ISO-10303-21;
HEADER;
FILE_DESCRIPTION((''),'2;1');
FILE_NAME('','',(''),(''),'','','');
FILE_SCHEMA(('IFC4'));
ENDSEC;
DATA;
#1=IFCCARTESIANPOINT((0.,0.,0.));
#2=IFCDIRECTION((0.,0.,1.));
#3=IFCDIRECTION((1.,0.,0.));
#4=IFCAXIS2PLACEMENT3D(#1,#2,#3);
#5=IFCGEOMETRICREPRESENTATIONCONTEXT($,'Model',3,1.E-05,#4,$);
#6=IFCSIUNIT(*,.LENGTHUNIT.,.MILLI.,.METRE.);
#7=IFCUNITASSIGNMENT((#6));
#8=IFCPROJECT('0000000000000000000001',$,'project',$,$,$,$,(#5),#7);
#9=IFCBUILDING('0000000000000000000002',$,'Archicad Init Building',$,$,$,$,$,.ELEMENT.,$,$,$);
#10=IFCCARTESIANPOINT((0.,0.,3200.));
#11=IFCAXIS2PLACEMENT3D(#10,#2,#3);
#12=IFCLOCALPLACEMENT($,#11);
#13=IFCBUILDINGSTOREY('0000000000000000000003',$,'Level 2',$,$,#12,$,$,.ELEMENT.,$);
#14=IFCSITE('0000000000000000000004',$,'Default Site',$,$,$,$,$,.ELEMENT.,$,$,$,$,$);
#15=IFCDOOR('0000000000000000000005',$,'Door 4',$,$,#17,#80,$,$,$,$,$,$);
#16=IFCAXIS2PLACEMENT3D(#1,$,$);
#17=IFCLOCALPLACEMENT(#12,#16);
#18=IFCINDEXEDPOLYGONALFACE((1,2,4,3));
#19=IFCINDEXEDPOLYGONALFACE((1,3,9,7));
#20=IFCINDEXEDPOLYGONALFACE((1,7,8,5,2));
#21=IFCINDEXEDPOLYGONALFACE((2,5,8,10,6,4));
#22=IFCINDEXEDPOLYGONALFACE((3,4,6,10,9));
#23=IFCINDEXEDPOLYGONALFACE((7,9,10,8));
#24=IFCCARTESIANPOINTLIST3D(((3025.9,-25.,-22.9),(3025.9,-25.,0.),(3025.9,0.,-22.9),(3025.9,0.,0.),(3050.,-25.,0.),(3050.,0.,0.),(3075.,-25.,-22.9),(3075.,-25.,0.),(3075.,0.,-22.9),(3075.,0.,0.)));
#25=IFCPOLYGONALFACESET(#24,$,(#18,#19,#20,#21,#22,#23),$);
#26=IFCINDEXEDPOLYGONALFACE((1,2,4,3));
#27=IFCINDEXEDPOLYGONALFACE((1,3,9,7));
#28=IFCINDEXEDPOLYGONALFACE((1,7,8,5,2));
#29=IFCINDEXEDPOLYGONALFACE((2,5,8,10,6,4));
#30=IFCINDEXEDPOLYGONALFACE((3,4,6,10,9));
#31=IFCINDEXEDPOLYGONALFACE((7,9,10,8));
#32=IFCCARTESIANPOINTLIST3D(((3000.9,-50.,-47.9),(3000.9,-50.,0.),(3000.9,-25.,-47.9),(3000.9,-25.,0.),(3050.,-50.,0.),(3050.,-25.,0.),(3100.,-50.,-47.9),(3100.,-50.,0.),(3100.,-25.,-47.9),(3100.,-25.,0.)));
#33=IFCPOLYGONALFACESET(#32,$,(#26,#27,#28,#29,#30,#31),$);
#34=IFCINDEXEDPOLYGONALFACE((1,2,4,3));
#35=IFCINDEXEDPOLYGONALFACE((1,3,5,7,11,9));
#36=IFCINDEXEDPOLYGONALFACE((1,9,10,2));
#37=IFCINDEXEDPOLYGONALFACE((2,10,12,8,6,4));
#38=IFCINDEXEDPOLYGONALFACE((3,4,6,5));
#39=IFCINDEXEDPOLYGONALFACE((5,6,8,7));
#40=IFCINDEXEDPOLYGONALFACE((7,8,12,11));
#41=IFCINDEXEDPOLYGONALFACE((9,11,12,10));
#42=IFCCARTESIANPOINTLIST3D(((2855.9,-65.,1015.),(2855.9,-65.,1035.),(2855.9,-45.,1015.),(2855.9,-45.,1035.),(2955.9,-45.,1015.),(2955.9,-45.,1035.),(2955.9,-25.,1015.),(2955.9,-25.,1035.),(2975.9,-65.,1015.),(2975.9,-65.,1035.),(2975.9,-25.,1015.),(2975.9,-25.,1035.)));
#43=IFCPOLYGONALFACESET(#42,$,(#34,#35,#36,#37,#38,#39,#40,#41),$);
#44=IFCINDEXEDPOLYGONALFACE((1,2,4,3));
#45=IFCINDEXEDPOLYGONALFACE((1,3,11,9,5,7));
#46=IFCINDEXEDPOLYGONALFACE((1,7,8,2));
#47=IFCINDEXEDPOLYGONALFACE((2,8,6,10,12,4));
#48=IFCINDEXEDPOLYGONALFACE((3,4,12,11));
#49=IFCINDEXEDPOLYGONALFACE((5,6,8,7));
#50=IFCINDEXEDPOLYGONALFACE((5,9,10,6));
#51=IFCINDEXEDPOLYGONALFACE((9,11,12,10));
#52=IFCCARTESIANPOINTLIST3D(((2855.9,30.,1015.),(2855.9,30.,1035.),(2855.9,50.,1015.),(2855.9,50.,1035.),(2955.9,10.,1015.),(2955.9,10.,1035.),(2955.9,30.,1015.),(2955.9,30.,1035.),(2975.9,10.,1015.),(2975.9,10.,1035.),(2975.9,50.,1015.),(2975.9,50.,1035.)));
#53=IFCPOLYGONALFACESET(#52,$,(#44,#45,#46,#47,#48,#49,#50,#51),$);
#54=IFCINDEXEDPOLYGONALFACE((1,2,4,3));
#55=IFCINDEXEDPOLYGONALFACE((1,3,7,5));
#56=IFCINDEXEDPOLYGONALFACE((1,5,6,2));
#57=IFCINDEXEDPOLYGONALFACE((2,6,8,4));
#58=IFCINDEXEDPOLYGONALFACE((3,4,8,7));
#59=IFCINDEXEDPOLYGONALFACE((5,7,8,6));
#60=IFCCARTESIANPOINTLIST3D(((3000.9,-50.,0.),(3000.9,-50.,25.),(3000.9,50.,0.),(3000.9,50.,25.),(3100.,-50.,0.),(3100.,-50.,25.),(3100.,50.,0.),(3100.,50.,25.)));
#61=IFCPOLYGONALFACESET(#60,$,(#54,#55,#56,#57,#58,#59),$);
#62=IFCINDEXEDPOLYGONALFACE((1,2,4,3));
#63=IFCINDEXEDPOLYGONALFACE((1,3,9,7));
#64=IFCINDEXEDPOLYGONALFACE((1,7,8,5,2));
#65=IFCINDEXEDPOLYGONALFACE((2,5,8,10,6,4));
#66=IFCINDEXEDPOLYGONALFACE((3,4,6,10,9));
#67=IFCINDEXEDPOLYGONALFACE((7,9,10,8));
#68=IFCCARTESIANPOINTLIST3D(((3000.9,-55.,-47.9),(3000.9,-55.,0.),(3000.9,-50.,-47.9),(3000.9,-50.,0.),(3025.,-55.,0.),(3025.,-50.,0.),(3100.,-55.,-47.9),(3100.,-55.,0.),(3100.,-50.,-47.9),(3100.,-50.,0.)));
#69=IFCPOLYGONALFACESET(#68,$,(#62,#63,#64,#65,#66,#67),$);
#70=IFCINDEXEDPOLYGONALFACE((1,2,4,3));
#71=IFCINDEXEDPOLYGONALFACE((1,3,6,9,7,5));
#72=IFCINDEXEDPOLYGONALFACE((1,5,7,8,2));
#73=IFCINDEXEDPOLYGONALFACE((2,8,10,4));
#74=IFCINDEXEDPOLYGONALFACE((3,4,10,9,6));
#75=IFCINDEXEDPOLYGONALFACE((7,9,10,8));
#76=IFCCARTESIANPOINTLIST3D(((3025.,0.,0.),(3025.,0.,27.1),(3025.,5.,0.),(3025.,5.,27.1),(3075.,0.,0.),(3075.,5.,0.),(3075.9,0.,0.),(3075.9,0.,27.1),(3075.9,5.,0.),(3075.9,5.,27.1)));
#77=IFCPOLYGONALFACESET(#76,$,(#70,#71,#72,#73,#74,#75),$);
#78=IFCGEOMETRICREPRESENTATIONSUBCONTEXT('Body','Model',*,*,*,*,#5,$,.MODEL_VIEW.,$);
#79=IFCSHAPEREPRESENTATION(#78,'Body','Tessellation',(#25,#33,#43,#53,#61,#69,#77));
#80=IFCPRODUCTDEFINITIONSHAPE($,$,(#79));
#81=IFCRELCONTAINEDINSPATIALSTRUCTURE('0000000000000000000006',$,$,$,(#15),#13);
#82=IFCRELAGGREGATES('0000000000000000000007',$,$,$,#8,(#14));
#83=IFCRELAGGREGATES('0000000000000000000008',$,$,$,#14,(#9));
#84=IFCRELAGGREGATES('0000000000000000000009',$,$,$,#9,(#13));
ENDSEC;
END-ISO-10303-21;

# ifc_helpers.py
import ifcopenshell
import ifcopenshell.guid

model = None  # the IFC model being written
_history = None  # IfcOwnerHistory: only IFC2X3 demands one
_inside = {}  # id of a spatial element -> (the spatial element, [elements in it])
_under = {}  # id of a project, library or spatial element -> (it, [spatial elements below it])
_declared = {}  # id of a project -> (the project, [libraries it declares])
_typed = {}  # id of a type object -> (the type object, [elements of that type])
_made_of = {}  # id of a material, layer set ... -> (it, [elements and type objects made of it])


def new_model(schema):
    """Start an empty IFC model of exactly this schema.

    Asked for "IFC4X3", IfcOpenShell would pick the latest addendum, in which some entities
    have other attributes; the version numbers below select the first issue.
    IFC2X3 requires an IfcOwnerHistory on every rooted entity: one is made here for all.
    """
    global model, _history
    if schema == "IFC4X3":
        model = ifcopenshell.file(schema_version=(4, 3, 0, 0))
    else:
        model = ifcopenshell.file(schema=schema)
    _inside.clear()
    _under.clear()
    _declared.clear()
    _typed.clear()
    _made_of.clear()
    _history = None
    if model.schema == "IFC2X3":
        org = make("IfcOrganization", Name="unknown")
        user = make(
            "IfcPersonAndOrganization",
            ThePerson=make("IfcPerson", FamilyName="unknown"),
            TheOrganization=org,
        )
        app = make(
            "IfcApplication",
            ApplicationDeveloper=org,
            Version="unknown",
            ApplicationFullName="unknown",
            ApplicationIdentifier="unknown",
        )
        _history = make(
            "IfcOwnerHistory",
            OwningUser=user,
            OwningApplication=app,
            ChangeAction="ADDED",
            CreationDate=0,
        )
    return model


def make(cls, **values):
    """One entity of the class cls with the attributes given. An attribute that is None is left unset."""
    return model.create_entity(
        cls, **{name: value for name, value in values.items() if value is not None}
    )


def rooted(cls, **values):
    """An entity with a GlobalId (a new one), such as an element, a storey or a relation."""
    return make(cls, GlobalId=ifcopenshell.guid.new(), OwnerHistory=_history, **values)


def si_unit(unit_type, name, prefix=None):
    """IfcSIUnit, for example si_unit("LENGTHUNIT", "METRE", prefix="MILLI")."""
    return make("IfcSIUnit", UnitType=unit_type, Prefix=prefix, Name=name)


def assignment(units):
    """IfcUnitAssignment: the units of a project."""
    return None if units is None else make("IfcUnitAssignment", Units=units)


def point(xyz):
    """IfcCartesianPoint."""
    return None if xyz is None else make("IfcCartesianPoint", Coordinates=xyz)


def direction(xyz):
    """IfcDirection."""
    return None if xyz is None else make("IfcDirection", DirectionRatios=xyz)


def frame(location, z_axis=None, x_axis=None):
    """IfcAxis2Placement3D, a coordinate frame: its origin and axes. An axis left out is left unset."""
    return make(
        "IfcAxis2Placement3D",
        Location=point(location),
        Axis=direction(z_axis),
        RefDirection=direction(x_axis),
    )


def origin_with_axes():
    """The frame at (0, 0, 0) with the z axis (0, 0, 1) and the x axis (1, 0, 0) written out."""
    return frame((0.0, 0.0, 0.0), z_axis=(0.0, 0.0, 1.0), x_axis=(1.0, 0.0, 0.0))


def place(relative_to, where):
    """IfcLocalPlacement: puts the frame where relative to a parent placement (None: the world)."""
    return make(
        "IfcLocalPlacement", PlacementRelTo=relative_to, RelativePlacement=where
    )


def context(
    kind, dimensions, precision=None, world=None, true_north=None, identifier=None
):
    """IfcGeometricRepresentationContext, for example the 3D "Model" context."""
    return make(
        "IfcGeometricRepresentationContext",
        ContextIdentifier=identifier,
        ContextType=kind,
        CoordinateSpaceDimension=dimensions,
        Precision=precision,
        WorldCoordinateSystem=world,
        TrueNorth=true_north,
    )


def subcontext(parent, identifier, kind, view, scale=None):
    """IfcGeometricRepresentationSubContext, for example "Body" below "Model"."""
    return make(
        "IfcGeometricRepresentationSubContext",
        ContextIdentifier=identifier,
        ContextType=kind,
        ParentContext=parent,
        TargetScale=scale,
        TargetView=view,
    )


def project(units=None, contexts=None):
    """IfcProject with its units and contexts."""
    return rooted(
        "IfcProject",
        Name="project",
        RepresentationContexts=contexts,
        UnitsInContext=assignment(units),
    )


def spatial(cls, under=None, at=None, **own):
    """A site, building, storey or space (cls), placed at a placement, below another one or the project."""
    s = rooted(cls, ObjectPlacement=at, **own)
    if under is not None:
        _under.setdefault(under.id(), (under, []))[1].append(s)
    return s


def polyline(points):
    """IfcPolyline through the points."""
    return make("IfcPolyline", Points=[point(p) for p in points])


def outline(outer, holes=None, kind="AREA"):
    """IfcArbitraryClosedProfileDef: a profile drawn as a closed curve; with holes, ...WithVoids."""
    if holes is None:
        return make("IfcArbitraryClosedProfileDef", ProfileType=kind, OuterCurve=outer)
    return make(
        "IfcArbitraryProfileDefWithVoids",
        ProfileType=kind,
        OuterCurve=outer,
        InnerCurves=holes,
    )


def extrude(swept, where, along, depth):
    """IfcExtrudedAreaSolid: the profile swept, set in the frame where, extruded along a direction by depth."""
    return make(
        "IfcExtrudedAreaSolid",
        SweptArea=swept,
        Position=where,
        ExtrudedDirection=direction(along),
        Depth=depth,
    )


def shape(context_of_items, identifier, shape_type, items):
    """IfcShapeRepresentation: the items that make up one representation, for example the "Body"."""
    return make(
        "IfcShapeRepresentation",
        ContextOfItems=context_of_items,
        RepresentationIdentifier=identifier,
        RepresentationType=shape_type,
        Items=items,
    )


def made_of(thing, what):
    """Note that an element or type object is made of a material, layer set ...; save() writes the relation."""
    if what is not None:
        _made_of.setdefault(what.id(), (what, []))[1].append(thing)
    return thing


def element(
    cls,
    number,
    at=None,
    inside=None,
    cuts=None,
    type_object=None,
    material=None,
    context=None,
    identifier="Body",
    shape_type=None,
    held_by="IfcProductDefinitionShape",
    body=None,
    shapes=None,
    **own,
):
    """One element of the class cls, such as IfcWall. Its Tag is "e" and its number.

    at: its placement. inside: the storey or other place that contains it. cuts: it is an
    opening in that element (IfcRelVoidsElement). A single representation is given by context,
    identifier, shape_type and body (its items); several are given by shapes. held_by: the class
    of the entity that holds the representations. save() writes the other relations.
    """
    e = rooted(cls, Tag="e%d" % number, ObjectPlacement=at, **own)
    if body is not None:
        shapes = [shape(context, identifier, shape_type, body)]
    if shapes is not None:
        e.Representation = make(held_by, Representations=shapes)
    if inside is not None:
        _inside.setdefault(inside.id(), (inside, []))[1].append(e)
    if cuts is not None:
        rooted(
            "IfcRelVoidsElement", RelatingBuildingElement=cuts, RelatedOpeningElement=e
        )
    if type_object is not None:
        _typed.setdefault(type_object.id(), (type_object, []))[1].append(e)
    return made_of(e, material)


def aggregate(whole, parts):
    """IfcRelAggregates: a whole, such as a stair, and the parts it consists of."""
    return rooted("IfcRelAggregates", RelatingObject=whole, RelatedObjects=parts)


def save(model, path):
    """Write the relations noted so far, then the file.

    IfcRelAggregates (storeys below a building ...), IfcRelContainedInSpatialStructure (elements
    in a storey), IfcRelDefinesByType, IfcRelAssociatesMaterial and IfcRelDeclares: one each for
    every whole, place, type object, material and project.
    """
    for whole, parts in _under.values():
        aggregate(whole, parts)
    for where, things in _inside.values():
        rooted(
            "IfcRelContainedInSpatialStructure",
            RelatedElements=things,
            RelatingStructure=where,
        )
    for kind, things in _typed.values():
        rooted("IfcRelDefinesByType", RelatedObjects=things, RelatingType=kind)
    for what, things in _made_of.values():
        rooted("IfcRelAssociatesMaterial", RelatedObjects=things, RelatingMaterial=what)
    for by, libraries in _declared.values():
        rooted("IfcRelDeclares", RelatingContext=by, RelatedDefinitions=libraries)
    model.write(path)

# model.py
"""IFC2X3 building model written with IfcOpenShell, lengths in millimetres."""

from ifc_helpers import new_model, si_unit, frame, origin_with_axes, place, context, subcontext, project, spatial, polyline, outline, extrude, element, save


model = new_model("IFC2X3")

# Units and contexts
model_context = context("Model", 3, precision=1e-05, world=origin_with_axes())
body_context = subcontext(model_context, "Body", "Model", "MODEL_VIEW")
ifc_project = project(units=[si_unit("LENGTHUNIT", "METRE", prefix="MILLI")], contexts=[model_context])

# Site, building, storey
site = spatial("IfcSite", under=ifc_project, Name="Default Site", CompositionType="ELEMENT")
building = spatial("IfcBuilding", under=site, Name="Archicad Init Building", CompositionType="ELEMENT")
storey_placement = place(None, frame((0.0, 0.0, 3200.0), z_axis=(0.0, 0.0, 1.0), x_axis=(1.0, 0.0, 0.0)))
storey = spatial("IfcBuildingStorey", under=building, at=storey_placement, Name="Level 2", CompositionType="ELEMENT")

# Door
door_1_placement = place(storey_placement, frame((3050.0, -50.0, 0.0), z_axis=(0.0, 0.0, 1.0), x_axis=(1.0, 0.0, 0.0)))
element("IfcDoor", 1, at=door_1_placement, inside=storey, Name="Door 4", context=body_context, shape_type="SweptSolid", body=[
    extrude(outline(polyline([(0.0, 0.0), (0.0, 2.1), (0.9, 2.1), (0.9, 0.0), (-24.1, 0.0), (-24.1, -22.9), (25.0, -22.9), (25.0, 0.0), (0.0, 0.0)])), frame((0.0, 25.0, 0.0), z_axis=(0.0, -1.0, 0.0), x_axis=(1.0, 0.0, 0.0)), (0.0, 0.0, -1.0), 25.0),
    extrude(outline(polyline([(0.0, 0.0), (0.0, 2.1), (0.9, 2.1), (0.9, 0.0), (-49.1, 0.0), (-49.1, -47.9), (50.0, -47.9), (50.0, 0.0), (0.0, 0.0)])), frame((0.0, 0.0, 0.0), z_axis=(0.0, -1.0, 0.0), x_axis=(1.0, 0.0, 0.0)), (0.0, 0.0, -1.0), 25.0),
    extrude(outline(polyline([(0.0, 0.0), (-49.1, 0.0), (-49.1, 35.0), (0.0, 35.0), (0.0, 0.0)])), frame((25.0, 25.0, 25.0), z_axis=(0.0, 0.0, 1.0), x_axis=(1.0, 0.0, 0.0)), (0.0, 0.0, 1.0), -47.9),
    extrude(outline(polyline([(0.0, 0.0), (0.0, -40.0), (-120.0, -40.0), (-120.0, -20.0), (-20.0, -20.0), (-20.0, 0.0), (0.0, 0.0)])), frame((-74.1, 25.0, 1015.0), z_axis=(0.0, 0.0, 1.0), x_axis=(1.0, 0.0, 0.0)), (0.0, 0.0, 1.0), 20.0),
    extrude(outline(polyline([(0.0, 0.0), (0.0, 40.0), (-120.0, 40.0), (-120.0, 20.0), (-20.0, 20.0), (-20.0, 0.0), (0.0, 0.0)])), frame((-74.1, 60.0, 1015.0), z_axis=(0.0, 0.0, 1.0), x_axis=(1.0, 0.0, 0.0)), (0.0, 0.0, 1.0), 20.0),
    extrude(outline(polyline([(0.0, 0.0), (-99.1, 0.0), (-99.1, 100.0), (0.0, 100.0), (0.0, 0.0)])), frame((50.0, 0.0, 0.0), z_axis=(0.0, 0.0, 1.0), x_axis=(1.0, 0.0, 0.0)), (0.0, 0.0, 1.0), 25.0),
    extrude(outline(polyline([(0.0, 0.0), (0.0, 27.1), (50.9, 27.1), (50.9, 0.0), (-24.1, 0.0), (-24.1, -47.9), (75.0, -47.9), (75.0, 0.0), (0.0, 0.0)])), frame((-25.0, -5.0, 0.0), z_axis=(0.0, -1.0, 0.0), x_axis=(1.0, 0.0, 0.0)), (0.0, 0.0, -1.0), 5.0),
    extrude(outline(polyline([(0.0, 0.0), (0.0, 27.1), (50.9, 27.1), (50.9, 0.0), (0.9, 0.0), (0.9, -22.9), (50.0, -22.9), (50.0, 0.0), (0.0, 0.0)])), frame((-25.0, 50.0, 0.0), z_axis=(0.0, -1.0, 0.0), x_axis=(1.0, 0.0, 0.0)), (0.0, 0.0, -1.0), 5.0),
])

save(model, "model.ifc")
